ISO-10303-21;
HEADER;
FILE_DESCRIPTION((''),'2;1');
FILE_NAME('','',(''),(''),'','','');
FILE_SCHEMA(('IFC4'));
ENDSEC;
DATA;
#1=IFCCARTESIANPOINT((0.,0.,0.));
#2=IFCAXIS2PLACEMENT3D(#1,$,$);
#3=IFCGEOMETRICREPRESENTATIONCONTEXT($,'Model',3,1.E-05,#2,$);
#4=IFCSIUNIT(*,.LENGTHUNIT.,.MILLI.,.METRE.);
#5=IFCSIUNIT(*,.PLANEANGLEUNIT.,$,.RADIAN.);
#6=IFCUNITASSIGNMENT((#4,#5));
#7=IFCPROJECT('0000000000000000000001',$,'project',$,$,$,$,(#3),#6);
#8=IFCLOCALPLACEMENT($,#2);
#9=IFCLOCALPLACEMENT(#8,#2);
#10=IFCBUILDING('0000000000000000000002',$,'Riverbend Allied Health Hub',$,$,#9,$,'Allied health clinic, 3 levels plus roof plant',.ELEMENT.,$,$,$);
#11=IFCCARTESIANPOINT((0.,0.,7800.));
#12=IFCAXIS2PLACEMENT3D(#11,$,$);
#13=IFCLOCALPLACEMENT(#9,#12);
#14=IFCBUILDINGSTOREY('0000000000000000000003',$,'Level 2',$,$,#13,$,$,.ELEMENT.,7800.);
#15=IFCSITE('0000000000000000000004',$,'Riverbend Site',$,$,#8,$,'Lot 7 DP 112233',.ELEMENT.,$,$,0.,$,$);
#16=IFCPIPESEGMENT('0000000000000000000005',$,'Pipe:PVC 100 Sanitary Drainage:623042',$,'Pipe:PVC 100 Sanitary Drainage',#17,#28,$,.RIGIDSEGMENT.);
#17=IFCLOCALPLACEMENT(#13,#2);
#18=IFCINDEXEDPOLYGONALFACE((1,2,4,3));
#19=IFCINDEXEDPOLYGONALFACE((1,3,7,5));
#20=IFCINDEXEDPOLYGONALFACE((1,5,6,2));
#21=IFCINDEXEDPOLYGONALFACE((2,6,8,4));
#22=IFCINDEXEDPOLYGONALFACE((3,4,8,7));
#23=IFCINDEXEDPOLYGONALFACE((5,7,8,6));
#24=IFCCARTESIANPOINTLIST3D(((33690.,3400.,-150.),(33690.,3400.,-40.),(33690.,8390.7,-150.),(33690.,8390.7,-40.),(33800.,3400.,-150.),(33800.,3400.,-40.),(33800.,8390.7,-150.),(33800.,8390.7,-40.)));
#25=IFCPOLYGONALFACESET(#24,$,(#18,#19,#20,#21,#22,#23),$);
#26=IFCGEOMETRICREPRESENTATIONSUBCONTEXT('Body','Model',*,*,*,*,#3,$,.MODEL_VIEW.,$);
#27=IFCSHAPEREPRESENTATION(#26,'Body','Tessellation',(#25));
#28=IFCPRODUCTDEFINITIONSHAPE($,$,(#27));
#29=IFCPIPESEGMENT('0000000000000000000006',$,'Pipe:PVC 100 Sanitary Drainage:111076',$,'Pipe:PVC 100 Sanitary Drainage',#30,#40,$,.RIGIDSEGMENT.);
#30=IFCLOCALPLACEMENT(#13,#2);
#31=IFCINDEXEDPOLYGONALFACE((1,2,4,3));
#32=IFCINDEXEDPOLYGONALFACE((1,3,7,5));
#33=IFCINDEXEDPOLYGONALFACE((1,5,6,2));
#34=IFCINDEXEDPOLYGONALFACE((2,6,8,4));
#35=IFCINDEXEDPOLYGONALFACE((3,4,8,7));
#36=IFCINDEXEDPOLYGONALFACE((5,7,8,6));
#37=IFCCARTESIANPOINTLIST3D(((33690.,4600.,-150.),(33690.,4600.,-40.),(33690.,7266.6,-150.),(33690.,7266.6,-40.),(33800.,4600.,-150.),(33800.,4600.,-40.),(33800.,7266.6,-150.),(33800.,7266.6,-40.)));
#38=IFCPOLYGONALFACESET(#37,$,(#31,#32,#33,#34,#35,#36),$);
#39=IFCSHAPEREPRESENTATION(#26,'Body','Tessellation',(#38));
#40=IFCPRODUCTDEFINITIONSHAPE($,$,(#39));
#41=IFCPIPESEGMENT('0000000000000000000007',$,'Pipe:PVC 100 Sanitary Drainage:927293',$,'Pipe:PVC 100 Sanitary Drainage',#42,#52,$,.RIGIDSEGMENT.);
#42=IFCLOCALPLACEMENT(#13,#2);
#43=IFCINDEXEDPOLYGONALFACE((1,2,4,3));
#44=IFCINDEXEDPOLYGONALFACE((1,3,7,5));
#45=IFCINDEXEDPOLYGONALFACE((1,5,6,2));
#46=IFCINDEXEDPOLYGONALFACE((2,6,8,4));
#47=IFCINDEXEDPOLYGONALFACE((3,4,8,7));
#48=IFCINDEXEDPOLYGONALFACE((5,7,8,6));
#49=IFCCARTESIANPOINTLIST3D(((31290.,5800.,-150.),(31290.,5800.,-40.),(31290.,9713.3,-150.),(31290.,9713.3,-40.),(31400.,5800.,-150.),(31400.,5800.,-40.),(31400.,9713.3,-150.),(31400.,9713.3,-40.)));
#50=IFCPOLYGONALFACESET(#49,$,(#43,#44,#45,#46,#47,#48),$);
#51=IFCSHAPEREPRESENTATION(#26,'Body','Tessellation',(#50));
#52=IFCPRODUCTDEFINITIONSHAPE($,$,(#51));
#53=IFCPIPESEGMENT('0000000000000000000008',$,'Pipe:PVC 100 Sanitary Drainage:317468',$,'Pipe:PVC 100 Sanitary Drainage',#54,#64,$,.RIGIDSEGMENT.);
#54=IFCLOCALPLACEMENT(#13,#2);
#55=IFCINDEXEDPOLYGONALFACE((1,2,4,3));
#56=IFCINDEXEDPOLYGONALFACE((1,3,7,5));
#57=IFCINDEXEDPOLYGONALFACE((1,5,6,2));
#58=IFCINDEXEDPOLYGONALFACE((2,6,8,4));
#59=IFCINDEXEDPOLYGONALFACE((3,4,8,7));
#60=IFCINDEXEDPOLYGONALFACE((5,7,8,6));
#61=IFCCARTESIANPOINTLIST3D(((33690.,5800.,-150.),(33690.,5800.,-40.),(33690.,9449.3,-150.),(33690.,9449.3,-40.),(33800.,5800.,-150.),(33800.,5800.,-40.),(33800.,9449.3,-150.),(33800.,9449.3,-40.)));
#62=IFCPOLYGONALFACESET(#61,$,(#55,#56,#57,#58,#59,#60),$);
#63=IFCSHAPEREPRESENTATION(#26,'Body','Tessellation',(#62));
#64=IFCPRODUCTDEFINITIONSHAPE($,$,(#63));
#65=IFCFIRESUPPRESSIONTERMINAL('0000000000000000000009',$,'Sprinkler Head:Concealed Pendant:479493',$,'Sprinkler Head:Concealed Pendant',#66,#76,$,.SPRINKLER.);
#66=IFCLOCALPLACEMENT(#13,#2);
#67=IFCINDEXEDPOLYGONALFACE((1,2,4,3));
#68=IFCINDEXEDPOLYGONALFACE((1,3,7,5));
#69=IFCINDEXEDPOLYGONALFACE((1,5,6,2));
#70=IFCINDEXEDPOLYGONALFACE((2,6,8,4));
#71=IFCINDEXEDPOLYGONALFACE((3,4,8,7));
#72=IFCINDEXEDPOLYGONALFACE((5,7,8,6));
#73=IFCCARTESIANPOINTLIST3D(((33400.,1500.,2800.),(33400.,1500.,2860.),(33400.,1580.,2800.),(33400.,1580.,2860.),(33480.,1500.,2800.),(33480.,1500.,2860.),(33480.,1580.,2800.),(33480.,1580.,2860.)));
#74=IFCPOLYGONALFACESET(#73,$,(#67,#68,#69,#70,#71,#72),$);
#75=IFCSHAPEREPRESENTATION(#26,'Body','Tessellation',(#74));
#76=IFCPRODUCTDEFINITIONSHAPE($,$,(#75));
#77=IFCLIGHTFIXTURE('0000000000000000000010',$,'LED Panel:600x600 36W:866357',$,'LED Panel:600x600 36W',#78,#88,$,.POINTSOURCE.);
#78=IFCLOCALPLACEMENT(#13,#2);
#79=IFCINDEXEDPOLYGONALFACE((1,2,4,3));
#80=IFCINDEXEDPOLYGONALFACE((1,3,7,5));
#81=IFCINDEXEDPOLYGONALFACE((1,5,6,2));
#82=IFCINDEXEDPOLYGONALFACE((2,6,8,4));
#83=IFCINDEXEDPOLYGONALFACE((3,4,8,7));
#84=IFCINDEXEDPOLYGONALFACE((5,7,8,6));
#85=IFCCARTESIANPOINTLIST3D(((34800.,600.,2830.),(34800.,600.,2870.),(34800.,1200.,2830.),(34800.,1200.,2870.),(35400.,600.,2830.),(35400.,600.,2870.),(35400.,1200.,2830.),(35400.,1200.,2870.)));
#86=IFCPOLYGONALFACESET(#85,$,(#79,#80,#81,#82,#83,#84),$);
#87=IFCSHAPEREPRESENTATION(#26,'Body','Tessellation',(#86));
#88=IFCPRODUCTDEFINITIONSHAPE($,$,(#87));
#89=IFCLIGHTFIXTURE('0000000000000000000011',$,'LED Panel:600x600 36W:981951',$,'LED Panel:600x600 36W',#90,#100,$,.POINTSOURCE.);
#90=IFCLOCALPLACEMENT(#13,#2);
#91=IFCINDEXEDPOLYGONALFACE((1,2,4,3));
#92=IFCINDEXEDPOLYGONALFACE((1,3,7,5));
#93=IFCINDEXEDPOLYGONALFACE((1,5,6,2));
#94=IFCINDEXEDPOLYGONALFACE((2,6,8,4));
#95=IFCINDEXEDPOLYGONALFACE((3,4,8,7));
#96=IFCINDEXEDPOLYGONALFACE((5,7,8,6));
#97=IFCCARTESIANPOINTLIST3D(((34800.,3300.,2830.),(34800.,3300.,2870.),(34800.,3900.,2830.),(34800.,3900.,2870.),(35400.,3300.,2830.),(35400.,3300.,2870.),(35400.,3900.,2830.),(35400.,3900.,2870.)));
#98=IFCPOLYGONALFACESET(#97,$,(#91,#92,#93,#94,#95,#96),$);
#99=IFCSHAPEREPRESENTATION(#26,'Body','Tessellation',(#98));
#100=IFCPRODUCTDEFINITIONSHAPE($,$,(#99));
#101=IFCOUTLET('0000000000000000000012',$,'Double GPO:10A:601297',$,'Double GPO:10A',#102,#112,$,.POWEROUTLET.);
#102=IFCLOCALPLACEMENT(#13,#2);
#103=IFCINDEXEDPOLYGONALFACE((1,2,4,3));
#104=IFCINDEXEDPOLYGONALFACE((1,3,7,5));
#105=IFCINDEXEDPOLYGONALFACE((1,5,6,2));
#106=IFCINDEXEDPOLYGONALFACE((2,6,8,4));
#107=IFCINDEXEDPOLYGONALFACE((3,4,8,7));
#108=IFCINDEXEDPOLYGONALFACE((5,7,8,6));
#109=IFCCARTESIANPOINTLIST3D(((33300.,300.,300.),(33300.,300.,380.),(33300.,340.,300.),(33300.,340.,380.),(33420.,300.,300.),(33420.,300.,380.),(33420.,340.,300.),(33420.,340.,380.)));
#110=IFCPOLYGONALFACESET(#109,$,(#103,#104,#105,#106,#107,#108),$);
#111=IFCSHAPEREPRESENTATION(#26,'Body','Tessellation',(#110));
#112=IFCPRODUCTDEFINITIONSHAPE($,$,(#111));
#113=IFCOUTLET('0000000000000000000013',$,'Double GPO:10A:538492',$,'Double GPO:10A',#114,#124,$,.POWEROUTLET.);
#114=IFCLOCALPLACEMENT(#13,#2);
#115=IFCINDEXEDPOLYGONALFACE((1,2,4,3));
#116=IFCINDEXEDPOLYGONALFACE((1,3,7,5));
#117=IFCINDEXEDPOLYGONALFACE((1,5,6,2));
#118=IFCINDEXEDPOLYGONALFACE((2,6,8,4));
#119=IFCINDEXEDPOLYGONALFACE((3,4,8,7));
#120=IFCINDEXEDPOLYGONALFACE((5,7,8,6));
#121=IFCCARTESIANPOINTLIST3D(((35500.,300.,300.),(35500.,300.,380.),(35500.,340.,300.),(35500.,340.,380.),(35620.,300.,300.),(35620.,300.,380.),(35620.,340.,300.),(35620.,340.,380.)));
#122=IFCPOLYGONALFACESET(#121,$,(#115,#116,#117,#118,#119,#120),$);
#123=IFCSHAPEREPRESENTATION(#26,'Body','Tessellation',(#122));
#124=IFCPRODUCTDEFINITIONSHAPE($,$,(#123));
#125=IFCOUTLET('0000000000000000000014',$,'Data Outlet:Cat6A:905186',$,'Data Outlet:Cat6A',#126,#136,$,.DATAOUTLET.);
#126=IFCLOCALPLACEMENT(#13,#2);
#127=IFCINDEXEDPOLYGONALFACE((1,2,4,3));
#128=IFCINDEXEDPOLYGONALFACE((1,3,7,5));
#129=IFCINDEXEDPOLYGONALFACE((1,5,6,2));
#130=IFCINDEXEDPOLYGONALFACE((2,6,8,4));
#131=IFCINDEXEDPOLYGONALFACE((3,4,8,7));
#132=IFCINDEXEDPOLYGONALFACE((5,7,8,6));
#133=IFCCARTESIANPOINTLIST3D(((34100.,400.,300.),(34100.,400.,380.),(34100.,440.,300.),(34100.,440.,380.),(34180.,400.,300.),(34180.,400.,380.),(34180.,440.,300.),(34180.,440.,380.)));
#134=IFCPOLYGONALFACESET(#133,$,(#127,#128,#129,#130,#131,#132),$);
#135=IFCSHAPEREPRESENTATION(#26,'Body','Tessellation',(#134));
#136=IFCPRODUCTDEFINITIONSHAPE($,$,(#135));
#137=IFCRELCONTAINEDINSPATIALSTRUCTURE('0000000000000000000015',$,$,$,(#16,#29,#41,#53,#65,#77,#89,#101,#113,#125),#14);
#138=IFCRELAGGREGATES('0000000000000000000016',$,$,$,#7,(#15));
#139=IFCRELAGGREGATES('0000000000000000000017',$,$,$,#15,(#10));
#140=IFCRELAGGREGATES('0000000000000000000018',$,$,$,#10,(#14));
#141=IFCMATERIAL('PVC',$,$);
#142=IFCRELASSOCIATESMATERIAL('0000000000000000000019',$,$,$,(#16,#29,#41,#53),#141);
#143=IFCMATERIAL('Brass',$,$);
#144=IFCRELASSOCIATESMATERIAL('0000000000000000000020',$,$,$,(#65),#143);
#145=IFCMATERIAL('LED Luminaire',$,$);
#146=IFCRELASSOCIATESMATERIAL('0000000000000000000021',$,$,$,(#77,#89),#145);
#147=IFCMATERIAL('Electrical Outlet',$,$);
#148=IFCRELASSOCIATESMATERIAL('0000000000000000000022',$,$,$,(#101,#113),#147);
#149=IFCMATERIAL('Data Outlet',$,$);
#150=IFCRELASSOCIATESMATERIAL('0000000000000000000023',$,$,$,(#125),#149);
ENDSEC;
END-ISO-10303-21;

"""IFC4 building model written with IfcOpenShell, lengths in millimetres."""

from ifc_helpers import new_model, si_unit, frame, frame_2d, origin, place, context, subcontext, project, spatial, rectangle, extrude, material, element, save


model = new_model("IFC4")

# Units and contexts
model_context = context("Model", 3, precision=1e-05, world=origin())
body_context = subcontext(model_context, "Body", "Model", "MODEL_VIEW")
ifc_project = project(units=[si_unit("LENGTHUNIT", "METRE", prefix="MILLI"), si_unit("PLANEANGLEUNIT", "RADIAN")], contexts=[model_context])

# Site, building, storey
site_placement = place(None, origin())
site = spatial("IfcSite", under=ifc_project, at=site_placement, Name="Riverbend Site", LongName="Lot 7 DP 112233", CompositionType="ELEMENT", RefElevation=0.0)
building_placement = place(site_placement, origin())
building = spatial("IfcBuilding", under=site, at=building_placement, Name="Riverbend Allied Health Hub", LongName="Allied health clinic, 3 levels plus roof plant", CompositionType="ELEMENT")
storey_placement = place(building_placement, frame((0.0, 0.0, 7800.0)))
storey = spatial("IfcBuildingStorey", under=building, at=storey_placement, Name="Level 2", CompositionType="ELEMENT", Elevation=7800.0)

# Pipe segments
ifc_material_1 = material(Name="PVC")
pipe_segment_1_placement = place(storey_placement, frame((33800.0, 3400.0, -150.0), z_axis=(0.0, 0.0, 1.0), x_axis=(0.0, 1.0, 0.0)))
element("IfcPipeSegment", 1, at=pipe_segment_1_placement, inside=storey, material=ifc_material_1, Name="Pipe:PVC 100 Sanitary Drainage:623042", ObjectType="Pipe:PVC 100 Sanitary Drainage", PredefinedType="RIGIDSEGMENT", context=body_context, shape_type="SweptSolid", body=[
    extrude(rectangle(XDim=4990.7, YDim=110.0, at=frame_2d((2495.3, 55.0))), origin(), (0.0, 0.0, 1.0), 110.0),
])
pipe_segment_2_placement = place(storey_placement, frame((33800.0, 4600.0, -150.0), z_axis=(0.0, 0.0, 1.0), x_axis=(0.0, 1.0, 0.0)))
element("IfcPipeSegment", 2, at=pipe_segment_2_placement, inside=storey, material=ifc_material_1, Name="Pipe:PVC 100 Sanitary Drainage:111076", ObjectType="Pipe:PVC 100 Sanitary Drainage", PredefinedType="RIGIDSEGMENT", context=body_context, shape_type="SweptSolid", body=[
    extrude(rectangle(XDim=2666.6, YDim=110.0, at=frame_2d((1333.3, 55.0))), origin(), (0.0, 0.0, 1.0), 110.0),
])
pipe_segment_3_placement = place(storey_placement, frame((31400.0, 5800.0, -150.0), z_axis=(0.0, 0.0, 1.0), x_axis=(0.0, 1.0, 0.0)))
element("IfcPipeSegment", 3, at=pipe_segment_3_placement, inside=storey, material=ifc_material_1, Name="Pipe:PVC 100 Sanitary Drainage:927293", ObjectType="Pipe:PVC 100 Sanitary Drainage", PredefinedType="RIGIDSEGMENT", context=body_context, shape_type="SweptSolid", body=[
    extrude(rectangle(XDim=3913.3, YDim=110.0, at=frame_2d((1956.6, 55.0))), origin(), (0.0, 0.0, 1.0), 110.0),
])
pipe_segment_4_placement = place(storey_placement, frame((33800.0, 5800.0, -150.0), z_axis=(0.0, 0.0, 1.0), x_axis=(0.0, 1.0, 0.0)))
element("IfcPipeSegment", 4, at=pipe_segment_4_placement, inside=storey, material=ifc_material_1, Name="Pipe:PVC 100 Sanitary Drainage:317468", ObjectType="Pipe:PVC 100 Sanitary Drainage", PredefinedType="RIGIDSEGMENT", context=body_context, shape_type="SweptSolid", body=[
    extrude(rectangle(XDim=3649.3, YDim=110.0, at=frame_2d((1824.7, 55.0))), origin(), (0.0, 0.0, 1.0), 110.0),
])

# Fire suppression terminal
ifc_material_2 = material(Name="Brass")
fire_suppression_terminal_placement = place(storey_placement, frame((33400.0, 1500.0, 2800.0)))
element("IfcFireSuppressionTerminal", 5, at=fire_suppression_terminal_placement, inside=storey, material=ifc_material_2, Name="Sprinkler Head:Concealed Pendant:479493", ObjectType="Sprinkler Head:Concealed Pendant", PredefinedType="SPRINKLER", context=body_context, shape_type="SweptSolid", body=[
    extrude(rectangle(XDim=80.0, YDim=80.0, at=frame_2d((40.0, 40.0))), origin(), (0.0, 0.0, 1.0), 60.0),
])

# Light fixtures
ifc_material_3 = material(Name="LED Luminaire")
for number, where, name in (
    (6, (34800.0, 600.0, 2830.0), "LED Panel:600x600 36W:866357"),
    (7, (34800.0, 3300.0, 2830.0), "LED Panel:600x600 36W:981951"),
):
    element("IfcLightFixture", number, at=place(storey_placement, frame(where)), inside=storey, material=ifc_material_3, Name=name, ObjectType="LED Panel:600x600 36W", PredefinedType="POINTSOURCE", context=body_context, shape_type="SweptSolid", body=[
        extrude(rectangle(XDim=600.0, YDim=600.0, at=frame_2d((300.0, 300.0))), origin(), (0.0, 0.0, 1.0), 40.0),
    ])

# Outlets
ifc_material_4 = material(Name="Electrical Outlet")
for number, where, name in (
    (8, (33300.0, 300.0, 300.0), "Double GPO:10A:601297"),
    (9, (35500.0, 300.0, 300.0), "Double GPO:10A:538492"),
):
    element("IfcOutlet", number, at=place(storey_placement, frame(where)), inside=storey, material=ifc_material_4, Name=name, ObjectType="Double GPO:10A", PredefinedType="POWEROUTLET", context=body_context, shape_type="SweptSolid", body=[
        extrude(rectangle(XDim=120.0, YDim=40.0, at=frame_2d((60.0, 20.0))), origin(), (0.0, 0.0, 1.0), 80.0),
    ])
ifc_material_5 = material(Name="Data Outlet")
outlet_placement = place(storey_placement, frame((34100.0, 400.0, 300.0)))
element("IfcOutlet", 10, at=outlet_placement, inside=storey, material=ifc_material_5, Name="Data Outlet:Cat6A:905186", ObjectType="Data Outlet:Cat6A", PredefinedType="DATAOUTLET", context=body_context, shape_type="SweptSolid", body=[
    extrude(rectangle(XDim=80.0, YDim=40.0, at=frame_2d((40.0, 20.0))), origin(), (0.0, 0.0, 1.0), 80.0),
])

save(model, "model.ifc")
